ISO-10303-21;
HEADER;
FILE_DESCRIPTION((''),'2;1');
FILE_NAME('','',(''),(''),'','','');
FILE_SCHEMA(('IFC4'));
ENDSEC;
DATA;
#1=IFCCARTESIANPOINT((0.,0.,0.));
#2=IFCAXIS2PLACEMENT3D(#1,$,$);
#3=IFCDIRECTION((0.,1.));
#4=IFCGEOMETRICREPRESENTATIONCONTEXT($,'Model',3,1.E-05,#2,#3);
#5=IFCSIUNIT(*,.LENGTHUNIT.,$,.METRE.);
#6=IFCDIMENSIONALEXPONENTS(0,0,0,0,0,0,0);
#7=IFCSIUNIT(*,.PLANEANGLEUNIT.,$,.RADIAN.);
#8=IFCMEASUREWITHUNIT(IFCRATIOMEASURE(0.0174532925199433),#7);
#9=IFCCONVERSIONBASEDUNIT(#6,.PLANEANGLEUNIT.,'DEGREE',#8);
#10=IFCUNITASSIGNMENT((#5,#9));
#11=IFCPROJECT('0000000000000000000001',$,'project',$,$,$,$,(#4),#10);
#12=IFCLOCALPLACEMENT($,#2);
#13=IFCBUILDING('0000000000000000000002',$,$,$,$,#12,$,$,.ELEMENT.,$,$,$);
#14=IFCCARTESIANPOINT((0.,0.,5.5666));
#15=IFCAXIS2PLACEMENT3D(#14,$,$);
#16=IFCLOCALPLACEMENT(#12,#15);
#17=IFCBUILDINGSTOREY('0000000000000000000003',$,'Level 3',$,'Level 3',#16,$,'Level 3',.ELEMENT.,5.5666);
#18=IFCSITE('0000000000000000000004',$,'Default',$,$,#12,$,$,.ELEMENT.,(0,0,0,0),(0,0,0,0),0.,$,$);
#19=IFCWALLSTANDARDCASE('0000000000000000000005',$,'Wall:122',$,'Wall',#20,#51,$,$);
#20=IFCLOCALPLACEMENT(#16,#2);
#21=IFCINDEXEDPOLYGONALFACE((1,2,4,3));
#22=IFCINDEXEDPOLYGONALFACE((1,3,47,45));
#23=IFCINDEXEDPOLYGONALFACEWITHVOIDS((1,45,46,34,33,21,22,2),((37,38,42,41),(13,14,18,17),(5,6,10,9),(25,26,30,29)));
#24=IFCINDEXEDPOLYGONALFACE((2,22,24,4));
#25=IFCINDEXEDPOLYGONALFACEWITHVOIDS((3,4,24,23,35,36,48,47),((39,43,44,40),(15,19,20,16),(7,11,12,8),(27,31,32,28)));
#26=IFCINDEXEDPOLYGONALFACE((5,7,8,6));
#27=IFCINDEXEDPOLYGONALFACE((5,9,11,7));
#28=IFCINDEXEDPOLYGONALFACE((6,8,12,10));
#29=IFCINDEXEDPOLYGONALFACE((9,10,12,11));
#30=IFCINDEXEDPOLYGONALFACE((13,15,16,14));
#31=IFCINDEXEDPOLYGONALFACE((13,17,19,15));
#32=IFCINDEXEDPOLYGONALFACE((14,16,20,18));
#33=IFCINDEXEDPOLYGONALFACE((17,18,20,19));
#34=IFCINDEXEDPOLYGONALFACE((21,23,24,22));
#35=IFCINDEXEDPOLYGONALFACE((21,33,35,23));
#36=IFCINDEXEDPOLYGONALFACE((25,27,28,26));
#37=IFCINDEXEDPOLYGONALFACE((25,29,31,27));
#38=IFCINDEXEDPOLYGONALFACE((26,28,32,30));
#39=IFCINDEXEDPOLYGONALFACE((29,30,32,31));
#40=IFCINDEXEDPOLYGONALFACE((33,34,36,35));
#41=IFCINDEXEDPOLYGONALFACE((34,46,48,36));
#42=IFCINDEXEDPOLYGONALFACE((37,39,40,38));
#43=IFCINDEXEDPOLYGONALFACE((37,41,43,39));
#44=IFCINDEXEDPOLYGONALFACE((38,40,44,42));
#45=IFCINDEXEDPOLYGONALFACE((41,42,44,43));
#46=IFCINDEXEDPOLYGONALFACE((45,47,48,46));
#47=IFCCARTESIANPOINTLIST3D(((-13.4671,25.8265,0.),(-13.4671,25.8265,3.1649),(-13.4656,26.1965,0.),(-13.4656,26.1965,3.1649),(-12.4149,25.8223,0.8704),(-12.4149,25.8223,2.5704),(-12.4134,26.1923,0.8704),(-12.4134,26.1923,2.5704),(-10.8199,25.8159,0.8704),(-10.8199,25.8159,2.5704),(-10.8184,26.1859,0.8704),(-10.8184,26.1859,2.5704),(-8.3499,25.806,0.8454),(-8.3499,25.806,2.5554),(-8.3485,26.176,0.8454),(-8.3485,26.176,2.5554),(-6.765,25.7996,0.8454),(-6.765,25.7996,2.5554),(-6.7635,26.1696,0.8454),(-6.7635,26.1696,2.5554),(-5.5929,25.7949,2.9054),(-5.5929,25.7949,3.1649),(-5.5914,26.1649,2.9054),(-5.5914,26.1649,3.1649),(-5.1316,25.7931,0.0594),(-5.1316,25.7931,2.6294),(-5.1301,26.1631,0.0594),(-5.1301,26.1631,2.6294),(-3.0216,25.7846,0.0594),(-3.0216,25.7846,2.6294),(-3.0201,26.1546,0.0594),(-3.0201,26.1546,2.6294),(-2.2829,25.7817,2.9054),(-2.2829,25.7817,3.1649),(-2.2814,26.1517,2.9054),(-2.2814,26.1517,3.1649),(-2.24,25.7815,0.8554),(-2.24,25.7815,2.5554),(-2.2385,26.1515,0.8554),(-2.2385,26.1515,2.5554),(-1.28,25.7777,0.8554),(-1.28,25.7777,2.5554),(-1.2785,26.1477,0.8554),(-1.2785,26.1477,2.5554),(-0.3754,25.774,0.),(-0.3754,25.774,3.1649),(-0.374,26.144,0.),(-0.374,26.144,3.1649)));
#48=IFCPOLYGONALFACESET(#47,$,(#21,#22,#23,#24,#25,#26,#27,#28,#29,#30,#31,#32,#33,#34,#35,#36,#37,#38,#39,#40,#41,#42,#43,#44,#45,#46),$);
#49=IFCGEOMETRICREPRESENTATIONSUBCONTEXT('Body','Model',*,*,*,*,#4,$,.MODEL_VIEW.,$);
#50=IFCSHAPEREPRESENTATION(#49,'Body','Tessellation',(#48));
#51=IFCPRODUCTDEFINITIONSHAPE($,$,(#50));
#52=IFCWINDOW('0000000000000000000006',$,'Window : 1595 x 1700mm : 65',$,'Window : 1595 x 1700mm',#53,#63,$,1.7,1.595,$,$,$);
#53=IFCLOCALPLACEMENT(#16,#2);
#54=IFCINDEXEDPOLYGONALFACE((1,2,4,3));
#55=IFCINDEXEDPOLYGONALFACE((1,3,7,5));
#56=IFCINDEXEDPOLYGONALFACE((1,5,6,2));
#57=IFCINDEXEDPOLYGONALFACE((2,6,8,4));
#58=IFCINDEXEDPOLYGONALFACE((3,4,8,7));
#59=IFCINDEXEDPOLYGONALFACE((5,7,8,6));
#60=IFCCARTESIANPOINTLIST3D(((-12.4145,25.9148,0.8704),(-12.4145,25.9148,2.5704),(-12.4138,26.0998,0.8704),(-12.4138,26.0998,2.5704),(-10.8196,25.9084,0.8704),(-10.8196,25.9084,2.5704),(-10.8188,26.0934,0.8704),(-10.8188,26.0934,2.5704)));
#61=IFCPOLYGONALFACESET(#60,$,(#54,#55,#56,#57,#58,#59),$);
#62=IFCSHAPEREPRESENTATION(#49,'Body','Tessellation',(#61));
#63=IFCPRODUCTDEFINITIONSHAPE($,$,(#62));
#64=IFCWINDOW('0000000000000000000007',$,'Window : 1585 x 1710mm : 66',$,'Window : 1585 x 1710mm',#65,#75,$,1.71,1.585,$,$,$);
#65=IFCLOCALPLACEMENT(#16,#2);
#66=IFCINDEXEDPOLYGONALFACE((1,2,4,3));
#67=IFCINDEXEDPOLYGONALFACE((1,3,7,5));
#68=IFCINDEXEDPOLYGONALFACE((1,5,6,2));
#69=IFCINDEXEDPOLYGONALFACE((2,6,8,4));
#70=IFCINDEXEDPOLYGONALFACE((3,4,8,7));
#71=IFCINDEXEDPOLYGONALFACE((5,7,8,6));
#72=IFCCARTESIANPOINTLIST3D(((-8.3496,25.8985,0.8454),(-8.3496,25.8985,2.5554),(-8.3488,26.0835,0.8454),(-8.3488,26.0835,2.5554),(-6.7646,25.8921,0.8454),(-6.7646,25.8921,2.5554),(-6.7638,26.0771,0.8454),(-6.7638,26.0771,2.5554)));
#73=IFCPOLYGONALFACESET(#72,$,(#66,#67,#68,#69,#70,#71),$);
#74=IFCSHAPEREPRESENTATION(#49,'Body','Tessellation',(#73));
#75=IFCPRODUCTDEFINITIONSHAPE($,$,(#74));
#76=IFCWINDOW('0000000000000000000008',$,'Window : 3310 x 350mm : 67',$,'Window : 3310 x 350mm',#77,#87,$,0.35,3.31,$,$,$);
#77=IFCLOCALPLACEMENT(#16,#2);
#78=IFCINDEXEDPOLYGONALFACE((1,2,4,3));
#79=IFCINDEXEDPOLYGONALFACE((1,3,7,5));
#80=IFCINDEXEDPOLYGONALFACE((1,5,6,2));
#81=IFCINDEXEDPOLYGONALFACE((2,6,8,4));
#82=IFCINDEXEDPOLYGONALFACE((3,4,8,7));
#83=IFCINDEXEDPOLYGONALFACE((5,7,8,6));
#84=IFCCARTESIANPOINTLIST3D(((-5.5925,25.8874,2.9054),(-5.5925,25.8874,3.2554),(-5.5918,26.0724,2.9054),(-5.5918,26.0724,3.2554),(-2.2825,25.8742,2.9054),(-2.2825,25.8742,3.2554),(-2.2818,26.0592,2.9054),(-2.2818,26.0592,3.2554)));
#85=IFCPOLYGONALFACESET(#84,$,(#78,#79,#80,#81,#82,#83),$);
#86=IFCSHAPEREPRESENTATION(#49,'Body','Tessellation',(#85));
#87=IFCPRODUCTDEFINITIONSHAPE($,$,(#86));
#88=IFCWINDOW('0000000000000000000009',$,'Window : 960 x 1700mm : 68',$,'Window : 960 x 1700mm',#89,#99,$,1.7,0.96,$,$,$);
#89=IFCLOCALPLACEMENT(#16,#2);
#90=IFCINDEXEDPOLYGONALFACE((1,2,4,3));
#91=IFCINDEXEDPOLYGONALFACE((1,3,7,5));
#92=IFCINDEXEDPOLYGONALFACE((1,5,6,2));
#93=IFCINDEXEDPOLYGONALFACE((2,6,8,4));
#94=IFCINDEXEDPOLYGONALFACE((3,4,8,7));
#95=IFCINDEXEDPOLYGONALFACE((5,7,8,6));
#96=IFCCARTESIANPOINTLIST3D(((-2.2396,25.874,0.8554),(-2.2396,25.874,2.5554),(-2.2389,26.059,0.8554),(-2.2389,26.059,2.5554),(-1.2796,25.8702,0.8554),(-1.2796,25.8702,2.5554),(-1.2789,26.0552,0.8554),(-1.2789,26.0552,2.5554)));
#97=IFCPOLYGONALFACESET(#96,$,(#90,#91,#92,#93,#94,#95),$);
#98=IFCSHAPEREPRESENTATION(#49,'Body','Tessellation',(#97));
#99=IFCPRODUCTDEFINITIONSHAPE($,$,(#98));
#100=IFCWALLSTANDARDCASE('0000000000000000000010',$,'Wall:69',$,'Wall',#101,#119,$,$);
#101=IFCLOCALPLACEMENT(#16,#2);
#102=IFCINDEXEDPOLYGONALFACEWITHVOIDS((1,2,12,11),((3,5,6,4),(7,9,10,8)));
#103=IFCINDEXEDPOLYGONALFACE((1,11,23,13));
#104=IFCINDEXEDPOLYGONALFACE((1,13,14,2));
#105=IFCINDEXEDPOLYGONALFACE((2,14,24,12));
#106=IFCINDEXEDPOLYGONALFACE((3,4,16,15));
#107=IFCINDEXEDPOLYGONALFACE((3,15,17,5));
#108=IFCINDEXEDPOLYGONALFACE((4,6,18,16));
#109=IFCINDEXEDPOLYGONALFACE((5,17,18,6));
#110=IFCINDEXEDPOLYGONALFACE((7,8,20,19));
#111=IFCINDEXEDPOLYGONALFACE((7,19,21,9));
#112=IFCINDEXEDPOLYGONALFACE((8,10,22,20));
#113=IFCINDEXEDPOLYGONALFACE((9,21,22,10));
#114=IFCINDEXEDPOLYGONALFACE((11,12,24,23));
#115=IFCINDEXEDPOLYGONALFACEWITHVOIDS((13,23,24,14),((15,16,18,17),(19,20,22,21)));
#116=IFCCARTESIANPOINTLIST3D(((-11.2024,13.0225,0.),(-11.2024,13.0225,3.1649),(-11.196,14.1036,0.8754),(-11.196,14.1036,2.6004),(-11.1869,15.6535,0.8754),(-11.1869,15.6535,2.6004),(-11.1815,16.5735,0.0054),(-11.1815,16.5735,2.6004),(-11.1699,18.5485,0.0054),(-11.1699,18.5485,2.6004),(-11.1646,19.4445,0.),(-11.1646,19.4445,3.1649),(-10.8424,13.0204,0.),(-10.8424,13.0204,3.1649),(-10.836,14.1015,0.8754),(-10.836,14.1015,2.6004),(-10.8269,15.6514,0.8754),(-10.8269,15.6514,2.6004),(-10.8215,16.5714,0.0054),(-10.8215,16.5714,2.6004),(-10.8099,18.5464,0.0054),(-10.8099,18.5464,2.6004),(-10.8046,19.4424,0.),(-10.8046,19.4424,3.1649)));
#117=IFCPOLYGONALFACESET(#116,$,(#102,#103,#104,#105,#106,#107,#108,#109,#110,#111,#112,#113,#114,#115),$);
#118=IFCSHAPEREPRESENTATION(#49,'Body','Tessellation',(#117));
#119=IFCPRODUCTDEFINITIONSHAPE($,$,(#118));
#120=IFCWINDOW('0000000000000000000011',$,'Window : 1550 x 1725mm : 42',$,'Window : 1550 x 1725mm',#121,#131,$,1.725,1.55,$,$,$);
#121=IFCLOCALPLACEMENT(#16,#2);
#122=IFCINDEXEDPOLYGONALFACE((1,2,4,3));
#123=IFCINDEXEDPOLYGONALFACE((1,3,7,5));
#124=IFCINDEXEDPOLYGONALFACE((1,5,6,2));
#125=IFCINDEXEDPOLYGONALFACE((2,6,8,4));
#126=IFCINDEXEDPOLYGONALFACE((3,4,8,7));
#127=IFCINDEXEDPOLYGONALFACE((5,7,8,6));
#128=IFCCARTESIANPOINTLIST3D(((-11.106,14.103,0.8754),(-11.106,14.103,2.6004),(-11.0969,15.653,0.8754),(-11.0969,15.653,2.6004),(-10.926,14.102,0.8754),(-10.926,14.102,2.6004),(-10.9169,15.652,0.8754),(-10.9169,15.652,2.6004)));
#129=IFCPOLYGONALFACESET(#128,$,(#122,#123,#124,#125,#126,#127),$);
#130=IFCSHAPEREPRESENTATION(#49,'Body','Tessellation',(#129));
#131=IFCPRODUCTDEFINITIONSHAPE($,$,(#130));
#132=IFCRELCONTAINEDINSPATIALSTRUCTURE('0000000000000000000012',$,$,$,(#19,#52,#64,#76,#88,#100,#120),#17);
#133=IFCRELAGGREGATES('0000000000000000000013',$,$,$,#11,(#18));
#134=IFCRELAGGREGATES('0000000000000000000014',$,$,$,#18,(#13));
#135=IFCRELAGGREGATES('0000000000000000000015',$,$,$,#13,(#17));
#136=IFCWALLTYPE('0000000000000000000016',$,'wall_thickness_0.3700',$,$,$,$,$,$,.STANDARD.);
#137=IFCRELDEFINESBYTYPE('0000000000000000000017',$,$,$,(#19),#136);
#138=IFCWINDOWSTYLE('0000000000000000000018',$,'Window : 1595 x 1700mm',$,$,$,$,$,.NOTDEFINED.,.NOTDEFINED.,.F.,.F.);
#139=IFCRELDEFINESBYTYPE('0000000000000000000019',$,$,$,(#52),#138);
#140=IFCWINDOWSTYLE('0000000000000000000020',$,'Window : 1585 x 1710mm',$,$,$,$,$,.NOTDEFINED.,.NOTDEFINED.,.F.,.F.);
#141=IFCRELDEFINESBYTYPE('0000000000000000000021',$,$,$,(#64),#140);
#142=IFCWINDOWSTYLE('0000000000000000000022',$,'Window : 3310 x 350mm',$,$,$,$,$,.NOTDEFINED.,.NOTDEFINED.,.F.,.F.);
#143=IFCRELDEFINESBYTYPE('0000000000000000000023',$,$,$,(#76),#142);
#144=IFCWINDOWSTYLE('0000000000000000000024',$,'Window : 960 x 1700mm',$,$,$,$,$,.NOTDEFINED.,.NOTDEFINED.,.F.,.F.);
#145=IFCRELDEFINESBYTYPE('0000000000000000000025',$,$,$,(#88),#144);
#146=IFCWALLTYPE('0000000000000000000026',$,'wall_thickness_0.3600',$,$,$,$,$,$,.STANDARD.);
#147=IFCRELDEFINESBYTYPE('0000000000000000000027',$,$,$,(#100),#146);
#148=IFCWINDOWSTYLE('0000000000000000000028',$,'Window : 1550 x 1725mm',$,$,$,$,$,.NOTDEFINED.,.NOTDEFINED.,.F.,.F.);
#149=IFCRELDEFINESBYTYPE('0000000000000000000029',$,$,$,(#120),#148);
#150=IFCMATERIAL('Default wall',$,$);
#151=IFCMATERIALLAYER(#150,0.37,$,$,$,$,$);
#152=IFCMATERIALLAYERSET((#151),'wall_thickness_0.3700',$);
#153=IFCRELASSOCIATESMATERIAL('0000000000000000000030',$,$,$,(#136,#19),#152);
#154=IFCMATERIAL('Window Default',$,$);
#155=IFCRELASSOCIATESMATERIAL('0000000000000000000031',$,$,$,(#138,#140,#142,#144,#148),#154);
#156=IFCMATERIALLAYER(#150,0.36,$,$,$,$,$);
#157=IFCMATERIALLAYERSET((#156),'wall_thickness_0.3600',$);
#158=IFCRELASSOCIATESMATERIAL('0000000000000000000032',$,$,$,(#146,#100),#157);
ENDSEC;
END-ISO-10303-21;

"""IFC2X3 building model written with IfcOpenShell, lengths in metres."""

from ifc_helpers import new_model, entity, si_unit, converted_unit, direction, frame, frame_2d, origin, origin_2d_with_axis, place, context, subcontext, project, spatial, polyline, rectangle, outline, extrude, source, transform, mapped, material, layer, layer_set, layer_usage, type_object, type_shapes, element, fill, save


model = new_model("IFC2X3")

# Units and contexts
model_context = context("Model", 3, precision=1e-05, world=origin(), true_north=direction((0.0, 1.0)))
body_context = subcontext(model_context, "Body", "Model", "MODEL_VIEW")
ifc_project = project(units=[si_unit("LENGTHUNIT", "METRE"), converted_unit("PLANEANGLEUNIT", "DEGREE", entity("IfcRatioMeasure", 0.0174532925199433), si_unit("PLANEANGLEUNIT", "RADIAN"), dimensions=[0, 0, 0, 0, 0, 0, 0])], contexts=[model_context])

# Site, building, storey
placement_1 = place(None, origin())
site = spatial("IfcSite", under=ifc_project, at=placement_1, Name="Default", CompositionType="ELEMENT", RefLatitude=(0, 0, 0, 0), RefLongitude=(0, 0, 0, 0), RefElevation=0.0)
building = spatial("IfcBuilding", under=site, at=placement_1, CompositionType="ELEMENT")
storey_placement = place(placement_1, frame((0.0, 0.0, 5.5666)))
storey = spatial("IfcBuildingStorey", under=building, at=storey_placement, Name="Level 3", ObjectType="Level 3", LongName="Level 3", CompositionType="ELEMENT", Elevation=5.5666)

# Shared definitions
ifc_material_1 = material(Name="Default wall")

# Shared definitions
ifc_material_2 = material(Name="Window Default")

# Wall, openings, windows
ifc_layer_1 = layer(ifc_material_1, 0.37)
ifc_layer_set_1 = layer_set([ifc_layer_1], Name="wall_thickness_0.3700")
ifc_layer_usage_1 = layer_usage(ifc_layer_set_1, "AXIS2", "POSITIVE", -0.185)
wall_type_1 = type_object("IfcWallType", Name="wall_thickness_0.3700", PredefinedType="STANDARD", material=ifc_layer_set_1)
wall_1_placement = place(storey_placement, frame((-13.4664, 26.0115, 0.0), z_axis=(0.0, 0.0, 1.0), x_axis=(0.999992, -0.004007, 0.0)))
wall_1 = element("IfcWallStandardCase", 1, at=wall_1_placement, inside=storey, type_object=wall_type_1, material=ifc_layer_usage_1, Name="Wall:122", ObjectType="Wall", context=body_context, shape_type="SweptSolid", body=[
    extrude(outline(polyline([(13.0918, -0.185), (13.0918, 0.185), (0.0, 0.185), (0.0, -0.185), (13.0918, -0.185)])), origin(), (0.0, 0.0, 1.0), 3.1649),
])
opening_1_placement = place(wall_1_placement, frame((8.3356, -0.185, 0.0594)))
element("IfcOpeningElement", 2, at=opening_1_placement, cuts=wall_1, ObjectType="Opening", context=body_context, shape_type="SweptSolid", body=[
    extrude(rectangle(XDim=2.11, YDim=2.57, at=frame_2d((1.285, 1.055), x_axis=(0.0, 1.0))), frame((0.0, 0.0, 0.0), z_axis=(0.0, 1.0, 0.0), x_axis=(0.0, 0.0, 1.0)), (0.0, 0.0, 1.0), 0.37),
])
opening_2_placement = place(wall_1_placement, frame((1.0522, -0.185, 0.8704)))
opening_2 = element("IfcOpeningElement", 3, at=opening_2_placement, cuts=wall_1, ObjectType="Opening", context=body_context, shape_type="SweptSolid", body=[
    extrude(rectangle(XDim=1.595, YDim=1.7, at=frame_2d((0.85, 0.7975), x_axis=(0.0, 1.0))), frame((0.0, 0.0, 0.0), z_axis=(0.0, 1.0, 0.0), x_axis=(0.0, 0.0, 1.0)), (0.0, 0.0, 1.0), 0.37),
])
opening_3_placement = place(wall_1_placement, frame((5.1172, -0.185, 0.8454)))
opening_3 = element("IfcOpeningElement", 4, at=opening_3_placement, cuts=wall_1, ObjectType="Opening", context=body_context, shape_type="SweptSolid", body=[
    extrude(rectangle(XDim=1.585, YDim=1.71, at=frame_2d((0.855, 0.7925), x_axis=(0.0, 1.0))), frame((0.0, 0.0, 0.0), z_axis=(0.0, 1.0, 0.0), x_axis=(0.0, 0.0, 1.0)), (0.0, 0.0, 1.0), 0.37),
])
opening_4_placement = place(wall_1_placement, frame((7.8743, -0.185, 2.9054)))
opening_4 = element("IfcOpeningElement", 5, at=opening_4_placement, cuts=wall_1, ObjectType="Opening", context=body_context, shape_type="SweptSolid", body=[
    extrude(rectangle(XDim=3.31, YDim=0.35, at=frame_2d((0.175, 1.655), x_axis=(0.0, 1.0))), frame((0.0, 0.0, 0.0), z_axis=(0.0, 1.0, 0.0), x_axis=(0.0, 0.0, 1.0)), (0.0, 0.0, 1.0), 0.37),
])
opening_5_placement = place(wall_1_placement, frame((11.2272, -0.185, 0.8554)))
opening_5 = element("IfcOpeningElement", 6, at=opening_5_placement, cuts=wall_1, ObjectType="Opening", context=body_context, shape_type="SweptSolid", body=[
    extrude(rectangle(XDim=0.96, YDim=1.7, at=frame_2d((0.85, 0.48), x_axis=(0.0, 1.0))), frame((0.0, 0.0, 0.0), z_axis=(0.0, 1.0, 0.0), x_axis=(0.0, 0.0, 1.0)), (0.0, 0.0, 1.0), 0.37),
])
window_style_1 = type_object("IfcWindowStyle", Name="Window : 1595 x 1700mm", ConstructionType="NOTDEFINED", OperationType="NOTDEFINED", ParameterTakesPrecedence=False, Sizeable=False, material=ifc_material_2)
shared_shape_1 = source(origin(), body_context, "Body", "SweptSolid", [
    extrude(rectangle(XDim=0.185, YDim=1.595, at=origin_2d_with_axis()), frame((0.7975, 0.185, 0.0), z_axis=(0.0, 0.0, 1.0), x_axis=(0.0, 1.0, 0.0)), (0.0, 0.0, 1.0), 1.7),
])
type_shapes(window_style_1, [shared_shape_1])
window_1_placement = place(opening_2_placement, origin())
window_1 = element("IfcWindow", 7, at=window_1_placement, inside=storey, type_object=window_style_1, Name="Window : 1595 x 1700mm : 65", ObjectType="Window : 1595 x 1700mm", OverallHeight=1.7, OverallWidth=1.595, context=body_context, shape_type="MappedRepresentation", body=[
    mapped(shared_shape_1, transform((0.0, 0.0, 0.0), scale=1.0)),
])
fill(opening_2, window_1)
window_style_2 = type_object("IfcWindowStyle", Name="Window : 1585 x 1710mm", ConstructionType="NOTDEFINED", OperationType="NOTDEFINED", ParameterTakesPrecedence=False, Sizeable=False, material=ifc_material_2)
shared_shape_2 = source(origin(), body_context, "Body", "SweptSolid", [
    extrude(rectangle(XDim=0.185, YDim=1.585, at=origin_2d_with_axis()), frame((0.7925, 0.185, 0.0), z_axis=(0.0, 0.0, 1.0), x_axis=(0.0, 1.0, 0.0)), (0.0, 0.0, 1.0), 1.71),
])
type_shapes(window_style_2, [shared_shape_2])
window_2_placement = place(opening_3_placement, origin())
window_2 = element("IfcWindow", 8, at=window_2_placement, inside=storey, type_object=window_style_2, Name="Window : 1585 x 1710mm : 66", ObjectType="Window : 1585 x 1710mm", OverallHeight=1.71, OverallWidth=1.585, context=body_context, shape_type="MappedRepresentation", body=[
    mapped(shared_shape_2, transform((0.0, 0.0, 0.0), scale=1.0)),
])
fill(opening_3, window_2)
window_style_3 = type_object("IfcWindowStyle", Name="Window : 3310 x 350mm", ConstructionType="NOTDEFINED", OperationType="NOTDEFINED", ParameterTakesPrecedence=False, Sizeable=False, material=ifc_material_2)
shared_shape_3 = source(origin(), body_context, "Body", "SweptSolid", [
    extrude(rectangle(XDim=0.185, YDim=3.31, at=origin_2d_with_axis()), frame((1.655, 0.185, 0.0), z_axis=(0.0, 0.0, 1.0), x_axis=(0.0, 1.0, 0.0)), (0.0, 0.0, 1.0), 0.35),
])
type_shapes(window_style_3, [shared_shape_3])
window_3_placement = place(opening_4_placement, origin())
window_3 = element("IfcWindow", 9, at=window_3_placement, inside=storey, type_object=window_style_3, Name="Window : 3310 x 350mm : 67", ObjectType="Window : 3310 x 350mm", OverallHeight=0.35, OverallWidth=3.31, context=body_context, shape_type="MappedRepresentation", body=[
    mapped(shared_shape_3, transform((0.0, 0.0, 0.0), scale=1.0)),
])
fill(opening_4, window_3)
window_style_4 = type_object("IfcWindowStyle", Name="Window : 960 x 1700mm", ConstructionType="NOTDEFINED", OperationType="NOTDEFINED", ParameterTakesPrecedence=False, Sizeable=False, material=ifc_material_2)
shared_shape_4 = source(origin(), body_context, "Body", "SweptSolid", [
    extrude(rectangle(XDim=0.185, YDim=0.96, at=origin_2d_with_axis()), frame((0.48, 0.185, 0.0), z_axis=(0.0, 0.0, 1.0), x_axis=(0.0, 1.0, 0.0)), (0.0, 0.0, 1.0), 1.7),
])
type_shapes(window_style_4, [shared_shape_4])
window_4_placement = place(opening_5_placement, origin())
window_4 = element("IfcWindow", 10, at=window_4_placement, inside=storey, type_object=window_style_4, Name="Window : 960 x 1700mm : 68", ObjectType="Window : 960 x 1700mm", OverallHeight=1.7, OverallWidth=0.96, context=body_context, shape_type="MappedRepresentation", body=[
    mapped(shared_shape_4, transform((0.0, 0.0, 0.0), scale=1.0)),
])
fill(opening_5, window_4)

# Wall, openings, window
ifc_layer_2 = layer(ifc_material_1, 0.36)
ifc_layer_set_2 = layer_set([ifc_layer_2], Name="wall_thickness_0.3600")
ifc_layer_usage_2 = layer_usage(ifc_layer_set_2, "AXIS2", "POSITIVE", -0.18)
wall_type_2 = type_object("IfcWallType", Name="wall_thickness_0.3600", PredefinedType="STANDARD", material=ifc_layer_set_2)
wall_2_placement = place(storey_placement, frame((-10.9846, 19.4435, 0.0), z_axis=(0.0, 0.0, 1.0), x_axis=(-0.005875, -0.999983, 0.0)))
wall_2 = element("IfcWallStandardCase", 11, at=wall_2_placement, inside=storey, type_object=wall_type_2, material=ifc_layer_usage_2, Name="Wall:69", ObjectType="Wall", context=body_context, shape_type="SweptSolid", body=[
    extrude(outline(polyline([(6.4221, -0.18), (6.4221, 0.18), (0.0, 0.18), (0.0, -0.18), (6.4221, -0.18)])), origin(), (0.0, 0.0, 1.0), 3.1649),
])
opening_6_placement = place(wall_2_placement, frame((0.896, -0.18, 0.0054)))
element("IfcOpeningElement", 12, at=opening_6_placement, cuts=wall_2, ObjectType="Opening", context=body_context, shape_type="SweptSolid", body=[
    extrude(rectangle(XDim=1.975, YDim=2.595, at=frame_2d((1.2975, 0.9875), x_axis=(0.0, 1.0))), frame((0.0, 0.0, 0.0), z_axis=(0.0, 1.0, 0.0), x_axis=(0.0, 0.0, 1.0)), (0.0, 0.0, 1.0), 0.36),
])
opening_7_placement = place(wall_2_placement, frame((3.791, -0.18, 0.8754)))
opening_7 = element("IfcOpeningElement", 13, at=opening_7_placement, cuts=wall_2, ObjectType="Opening", context=body_context, shape_type="SweptSolid", body=[
    extrude(rectangle(XDim=1.55, YDim=1.725, at=frame_2d((0.8625, 0.775), x_axis=(0.0, 1.0))), frame((0.0, 0.0, 0.0), z_axis=(0.0, 1.0, 0.0), x_axis=(0.0, 0.0, 1.0)), (0.0, 0.0, 1.0), 0.36),
])
window_style_5 = type_object("IfcWindowStyle", Name="Window : 1550 x 1725mm", ConstructionType="NOTDEFINED", OperationType="NOTDEFINED", ParameterTakesPrecedence=False, Sizeable=False, material=ifc_material_2)
shared_shape_5 = source(origin(), body_context, "Body", "SweptSolid", [
    extrude(rectangle(XDim=0.18, YDim=1.55, at=origin_2d_with_axis()), frame((0.775, 0.18, 0.0), z_axis=(0.0, 0.0, 1.0), x_axis=(0.0, 1.0, 0.0)), (0.0, 0.0, 1.0), 1.725),
])
type_shapes(window_style_5, [shared_shape_5])
window_5_placement = place(opening_7_placement, origin())
window_5 = element("IfcWindow", 14, at=window_5_placement, inside=storey, type_object=window_style_5, Name="Window : 1550 x 1725mm : 42", ObjectType="Window : 1550 x 1725mm", OverallHeight=1.725, OverallWidth=1.55, context=body_context, shape_type="MappedRepresentation", body=[
    mapped(shared_shape_5, transform((0.0, 0.0, 0.0), scale=1.0)),
])
fill(opening_7, window_5)

save(model, "model.ifc")
